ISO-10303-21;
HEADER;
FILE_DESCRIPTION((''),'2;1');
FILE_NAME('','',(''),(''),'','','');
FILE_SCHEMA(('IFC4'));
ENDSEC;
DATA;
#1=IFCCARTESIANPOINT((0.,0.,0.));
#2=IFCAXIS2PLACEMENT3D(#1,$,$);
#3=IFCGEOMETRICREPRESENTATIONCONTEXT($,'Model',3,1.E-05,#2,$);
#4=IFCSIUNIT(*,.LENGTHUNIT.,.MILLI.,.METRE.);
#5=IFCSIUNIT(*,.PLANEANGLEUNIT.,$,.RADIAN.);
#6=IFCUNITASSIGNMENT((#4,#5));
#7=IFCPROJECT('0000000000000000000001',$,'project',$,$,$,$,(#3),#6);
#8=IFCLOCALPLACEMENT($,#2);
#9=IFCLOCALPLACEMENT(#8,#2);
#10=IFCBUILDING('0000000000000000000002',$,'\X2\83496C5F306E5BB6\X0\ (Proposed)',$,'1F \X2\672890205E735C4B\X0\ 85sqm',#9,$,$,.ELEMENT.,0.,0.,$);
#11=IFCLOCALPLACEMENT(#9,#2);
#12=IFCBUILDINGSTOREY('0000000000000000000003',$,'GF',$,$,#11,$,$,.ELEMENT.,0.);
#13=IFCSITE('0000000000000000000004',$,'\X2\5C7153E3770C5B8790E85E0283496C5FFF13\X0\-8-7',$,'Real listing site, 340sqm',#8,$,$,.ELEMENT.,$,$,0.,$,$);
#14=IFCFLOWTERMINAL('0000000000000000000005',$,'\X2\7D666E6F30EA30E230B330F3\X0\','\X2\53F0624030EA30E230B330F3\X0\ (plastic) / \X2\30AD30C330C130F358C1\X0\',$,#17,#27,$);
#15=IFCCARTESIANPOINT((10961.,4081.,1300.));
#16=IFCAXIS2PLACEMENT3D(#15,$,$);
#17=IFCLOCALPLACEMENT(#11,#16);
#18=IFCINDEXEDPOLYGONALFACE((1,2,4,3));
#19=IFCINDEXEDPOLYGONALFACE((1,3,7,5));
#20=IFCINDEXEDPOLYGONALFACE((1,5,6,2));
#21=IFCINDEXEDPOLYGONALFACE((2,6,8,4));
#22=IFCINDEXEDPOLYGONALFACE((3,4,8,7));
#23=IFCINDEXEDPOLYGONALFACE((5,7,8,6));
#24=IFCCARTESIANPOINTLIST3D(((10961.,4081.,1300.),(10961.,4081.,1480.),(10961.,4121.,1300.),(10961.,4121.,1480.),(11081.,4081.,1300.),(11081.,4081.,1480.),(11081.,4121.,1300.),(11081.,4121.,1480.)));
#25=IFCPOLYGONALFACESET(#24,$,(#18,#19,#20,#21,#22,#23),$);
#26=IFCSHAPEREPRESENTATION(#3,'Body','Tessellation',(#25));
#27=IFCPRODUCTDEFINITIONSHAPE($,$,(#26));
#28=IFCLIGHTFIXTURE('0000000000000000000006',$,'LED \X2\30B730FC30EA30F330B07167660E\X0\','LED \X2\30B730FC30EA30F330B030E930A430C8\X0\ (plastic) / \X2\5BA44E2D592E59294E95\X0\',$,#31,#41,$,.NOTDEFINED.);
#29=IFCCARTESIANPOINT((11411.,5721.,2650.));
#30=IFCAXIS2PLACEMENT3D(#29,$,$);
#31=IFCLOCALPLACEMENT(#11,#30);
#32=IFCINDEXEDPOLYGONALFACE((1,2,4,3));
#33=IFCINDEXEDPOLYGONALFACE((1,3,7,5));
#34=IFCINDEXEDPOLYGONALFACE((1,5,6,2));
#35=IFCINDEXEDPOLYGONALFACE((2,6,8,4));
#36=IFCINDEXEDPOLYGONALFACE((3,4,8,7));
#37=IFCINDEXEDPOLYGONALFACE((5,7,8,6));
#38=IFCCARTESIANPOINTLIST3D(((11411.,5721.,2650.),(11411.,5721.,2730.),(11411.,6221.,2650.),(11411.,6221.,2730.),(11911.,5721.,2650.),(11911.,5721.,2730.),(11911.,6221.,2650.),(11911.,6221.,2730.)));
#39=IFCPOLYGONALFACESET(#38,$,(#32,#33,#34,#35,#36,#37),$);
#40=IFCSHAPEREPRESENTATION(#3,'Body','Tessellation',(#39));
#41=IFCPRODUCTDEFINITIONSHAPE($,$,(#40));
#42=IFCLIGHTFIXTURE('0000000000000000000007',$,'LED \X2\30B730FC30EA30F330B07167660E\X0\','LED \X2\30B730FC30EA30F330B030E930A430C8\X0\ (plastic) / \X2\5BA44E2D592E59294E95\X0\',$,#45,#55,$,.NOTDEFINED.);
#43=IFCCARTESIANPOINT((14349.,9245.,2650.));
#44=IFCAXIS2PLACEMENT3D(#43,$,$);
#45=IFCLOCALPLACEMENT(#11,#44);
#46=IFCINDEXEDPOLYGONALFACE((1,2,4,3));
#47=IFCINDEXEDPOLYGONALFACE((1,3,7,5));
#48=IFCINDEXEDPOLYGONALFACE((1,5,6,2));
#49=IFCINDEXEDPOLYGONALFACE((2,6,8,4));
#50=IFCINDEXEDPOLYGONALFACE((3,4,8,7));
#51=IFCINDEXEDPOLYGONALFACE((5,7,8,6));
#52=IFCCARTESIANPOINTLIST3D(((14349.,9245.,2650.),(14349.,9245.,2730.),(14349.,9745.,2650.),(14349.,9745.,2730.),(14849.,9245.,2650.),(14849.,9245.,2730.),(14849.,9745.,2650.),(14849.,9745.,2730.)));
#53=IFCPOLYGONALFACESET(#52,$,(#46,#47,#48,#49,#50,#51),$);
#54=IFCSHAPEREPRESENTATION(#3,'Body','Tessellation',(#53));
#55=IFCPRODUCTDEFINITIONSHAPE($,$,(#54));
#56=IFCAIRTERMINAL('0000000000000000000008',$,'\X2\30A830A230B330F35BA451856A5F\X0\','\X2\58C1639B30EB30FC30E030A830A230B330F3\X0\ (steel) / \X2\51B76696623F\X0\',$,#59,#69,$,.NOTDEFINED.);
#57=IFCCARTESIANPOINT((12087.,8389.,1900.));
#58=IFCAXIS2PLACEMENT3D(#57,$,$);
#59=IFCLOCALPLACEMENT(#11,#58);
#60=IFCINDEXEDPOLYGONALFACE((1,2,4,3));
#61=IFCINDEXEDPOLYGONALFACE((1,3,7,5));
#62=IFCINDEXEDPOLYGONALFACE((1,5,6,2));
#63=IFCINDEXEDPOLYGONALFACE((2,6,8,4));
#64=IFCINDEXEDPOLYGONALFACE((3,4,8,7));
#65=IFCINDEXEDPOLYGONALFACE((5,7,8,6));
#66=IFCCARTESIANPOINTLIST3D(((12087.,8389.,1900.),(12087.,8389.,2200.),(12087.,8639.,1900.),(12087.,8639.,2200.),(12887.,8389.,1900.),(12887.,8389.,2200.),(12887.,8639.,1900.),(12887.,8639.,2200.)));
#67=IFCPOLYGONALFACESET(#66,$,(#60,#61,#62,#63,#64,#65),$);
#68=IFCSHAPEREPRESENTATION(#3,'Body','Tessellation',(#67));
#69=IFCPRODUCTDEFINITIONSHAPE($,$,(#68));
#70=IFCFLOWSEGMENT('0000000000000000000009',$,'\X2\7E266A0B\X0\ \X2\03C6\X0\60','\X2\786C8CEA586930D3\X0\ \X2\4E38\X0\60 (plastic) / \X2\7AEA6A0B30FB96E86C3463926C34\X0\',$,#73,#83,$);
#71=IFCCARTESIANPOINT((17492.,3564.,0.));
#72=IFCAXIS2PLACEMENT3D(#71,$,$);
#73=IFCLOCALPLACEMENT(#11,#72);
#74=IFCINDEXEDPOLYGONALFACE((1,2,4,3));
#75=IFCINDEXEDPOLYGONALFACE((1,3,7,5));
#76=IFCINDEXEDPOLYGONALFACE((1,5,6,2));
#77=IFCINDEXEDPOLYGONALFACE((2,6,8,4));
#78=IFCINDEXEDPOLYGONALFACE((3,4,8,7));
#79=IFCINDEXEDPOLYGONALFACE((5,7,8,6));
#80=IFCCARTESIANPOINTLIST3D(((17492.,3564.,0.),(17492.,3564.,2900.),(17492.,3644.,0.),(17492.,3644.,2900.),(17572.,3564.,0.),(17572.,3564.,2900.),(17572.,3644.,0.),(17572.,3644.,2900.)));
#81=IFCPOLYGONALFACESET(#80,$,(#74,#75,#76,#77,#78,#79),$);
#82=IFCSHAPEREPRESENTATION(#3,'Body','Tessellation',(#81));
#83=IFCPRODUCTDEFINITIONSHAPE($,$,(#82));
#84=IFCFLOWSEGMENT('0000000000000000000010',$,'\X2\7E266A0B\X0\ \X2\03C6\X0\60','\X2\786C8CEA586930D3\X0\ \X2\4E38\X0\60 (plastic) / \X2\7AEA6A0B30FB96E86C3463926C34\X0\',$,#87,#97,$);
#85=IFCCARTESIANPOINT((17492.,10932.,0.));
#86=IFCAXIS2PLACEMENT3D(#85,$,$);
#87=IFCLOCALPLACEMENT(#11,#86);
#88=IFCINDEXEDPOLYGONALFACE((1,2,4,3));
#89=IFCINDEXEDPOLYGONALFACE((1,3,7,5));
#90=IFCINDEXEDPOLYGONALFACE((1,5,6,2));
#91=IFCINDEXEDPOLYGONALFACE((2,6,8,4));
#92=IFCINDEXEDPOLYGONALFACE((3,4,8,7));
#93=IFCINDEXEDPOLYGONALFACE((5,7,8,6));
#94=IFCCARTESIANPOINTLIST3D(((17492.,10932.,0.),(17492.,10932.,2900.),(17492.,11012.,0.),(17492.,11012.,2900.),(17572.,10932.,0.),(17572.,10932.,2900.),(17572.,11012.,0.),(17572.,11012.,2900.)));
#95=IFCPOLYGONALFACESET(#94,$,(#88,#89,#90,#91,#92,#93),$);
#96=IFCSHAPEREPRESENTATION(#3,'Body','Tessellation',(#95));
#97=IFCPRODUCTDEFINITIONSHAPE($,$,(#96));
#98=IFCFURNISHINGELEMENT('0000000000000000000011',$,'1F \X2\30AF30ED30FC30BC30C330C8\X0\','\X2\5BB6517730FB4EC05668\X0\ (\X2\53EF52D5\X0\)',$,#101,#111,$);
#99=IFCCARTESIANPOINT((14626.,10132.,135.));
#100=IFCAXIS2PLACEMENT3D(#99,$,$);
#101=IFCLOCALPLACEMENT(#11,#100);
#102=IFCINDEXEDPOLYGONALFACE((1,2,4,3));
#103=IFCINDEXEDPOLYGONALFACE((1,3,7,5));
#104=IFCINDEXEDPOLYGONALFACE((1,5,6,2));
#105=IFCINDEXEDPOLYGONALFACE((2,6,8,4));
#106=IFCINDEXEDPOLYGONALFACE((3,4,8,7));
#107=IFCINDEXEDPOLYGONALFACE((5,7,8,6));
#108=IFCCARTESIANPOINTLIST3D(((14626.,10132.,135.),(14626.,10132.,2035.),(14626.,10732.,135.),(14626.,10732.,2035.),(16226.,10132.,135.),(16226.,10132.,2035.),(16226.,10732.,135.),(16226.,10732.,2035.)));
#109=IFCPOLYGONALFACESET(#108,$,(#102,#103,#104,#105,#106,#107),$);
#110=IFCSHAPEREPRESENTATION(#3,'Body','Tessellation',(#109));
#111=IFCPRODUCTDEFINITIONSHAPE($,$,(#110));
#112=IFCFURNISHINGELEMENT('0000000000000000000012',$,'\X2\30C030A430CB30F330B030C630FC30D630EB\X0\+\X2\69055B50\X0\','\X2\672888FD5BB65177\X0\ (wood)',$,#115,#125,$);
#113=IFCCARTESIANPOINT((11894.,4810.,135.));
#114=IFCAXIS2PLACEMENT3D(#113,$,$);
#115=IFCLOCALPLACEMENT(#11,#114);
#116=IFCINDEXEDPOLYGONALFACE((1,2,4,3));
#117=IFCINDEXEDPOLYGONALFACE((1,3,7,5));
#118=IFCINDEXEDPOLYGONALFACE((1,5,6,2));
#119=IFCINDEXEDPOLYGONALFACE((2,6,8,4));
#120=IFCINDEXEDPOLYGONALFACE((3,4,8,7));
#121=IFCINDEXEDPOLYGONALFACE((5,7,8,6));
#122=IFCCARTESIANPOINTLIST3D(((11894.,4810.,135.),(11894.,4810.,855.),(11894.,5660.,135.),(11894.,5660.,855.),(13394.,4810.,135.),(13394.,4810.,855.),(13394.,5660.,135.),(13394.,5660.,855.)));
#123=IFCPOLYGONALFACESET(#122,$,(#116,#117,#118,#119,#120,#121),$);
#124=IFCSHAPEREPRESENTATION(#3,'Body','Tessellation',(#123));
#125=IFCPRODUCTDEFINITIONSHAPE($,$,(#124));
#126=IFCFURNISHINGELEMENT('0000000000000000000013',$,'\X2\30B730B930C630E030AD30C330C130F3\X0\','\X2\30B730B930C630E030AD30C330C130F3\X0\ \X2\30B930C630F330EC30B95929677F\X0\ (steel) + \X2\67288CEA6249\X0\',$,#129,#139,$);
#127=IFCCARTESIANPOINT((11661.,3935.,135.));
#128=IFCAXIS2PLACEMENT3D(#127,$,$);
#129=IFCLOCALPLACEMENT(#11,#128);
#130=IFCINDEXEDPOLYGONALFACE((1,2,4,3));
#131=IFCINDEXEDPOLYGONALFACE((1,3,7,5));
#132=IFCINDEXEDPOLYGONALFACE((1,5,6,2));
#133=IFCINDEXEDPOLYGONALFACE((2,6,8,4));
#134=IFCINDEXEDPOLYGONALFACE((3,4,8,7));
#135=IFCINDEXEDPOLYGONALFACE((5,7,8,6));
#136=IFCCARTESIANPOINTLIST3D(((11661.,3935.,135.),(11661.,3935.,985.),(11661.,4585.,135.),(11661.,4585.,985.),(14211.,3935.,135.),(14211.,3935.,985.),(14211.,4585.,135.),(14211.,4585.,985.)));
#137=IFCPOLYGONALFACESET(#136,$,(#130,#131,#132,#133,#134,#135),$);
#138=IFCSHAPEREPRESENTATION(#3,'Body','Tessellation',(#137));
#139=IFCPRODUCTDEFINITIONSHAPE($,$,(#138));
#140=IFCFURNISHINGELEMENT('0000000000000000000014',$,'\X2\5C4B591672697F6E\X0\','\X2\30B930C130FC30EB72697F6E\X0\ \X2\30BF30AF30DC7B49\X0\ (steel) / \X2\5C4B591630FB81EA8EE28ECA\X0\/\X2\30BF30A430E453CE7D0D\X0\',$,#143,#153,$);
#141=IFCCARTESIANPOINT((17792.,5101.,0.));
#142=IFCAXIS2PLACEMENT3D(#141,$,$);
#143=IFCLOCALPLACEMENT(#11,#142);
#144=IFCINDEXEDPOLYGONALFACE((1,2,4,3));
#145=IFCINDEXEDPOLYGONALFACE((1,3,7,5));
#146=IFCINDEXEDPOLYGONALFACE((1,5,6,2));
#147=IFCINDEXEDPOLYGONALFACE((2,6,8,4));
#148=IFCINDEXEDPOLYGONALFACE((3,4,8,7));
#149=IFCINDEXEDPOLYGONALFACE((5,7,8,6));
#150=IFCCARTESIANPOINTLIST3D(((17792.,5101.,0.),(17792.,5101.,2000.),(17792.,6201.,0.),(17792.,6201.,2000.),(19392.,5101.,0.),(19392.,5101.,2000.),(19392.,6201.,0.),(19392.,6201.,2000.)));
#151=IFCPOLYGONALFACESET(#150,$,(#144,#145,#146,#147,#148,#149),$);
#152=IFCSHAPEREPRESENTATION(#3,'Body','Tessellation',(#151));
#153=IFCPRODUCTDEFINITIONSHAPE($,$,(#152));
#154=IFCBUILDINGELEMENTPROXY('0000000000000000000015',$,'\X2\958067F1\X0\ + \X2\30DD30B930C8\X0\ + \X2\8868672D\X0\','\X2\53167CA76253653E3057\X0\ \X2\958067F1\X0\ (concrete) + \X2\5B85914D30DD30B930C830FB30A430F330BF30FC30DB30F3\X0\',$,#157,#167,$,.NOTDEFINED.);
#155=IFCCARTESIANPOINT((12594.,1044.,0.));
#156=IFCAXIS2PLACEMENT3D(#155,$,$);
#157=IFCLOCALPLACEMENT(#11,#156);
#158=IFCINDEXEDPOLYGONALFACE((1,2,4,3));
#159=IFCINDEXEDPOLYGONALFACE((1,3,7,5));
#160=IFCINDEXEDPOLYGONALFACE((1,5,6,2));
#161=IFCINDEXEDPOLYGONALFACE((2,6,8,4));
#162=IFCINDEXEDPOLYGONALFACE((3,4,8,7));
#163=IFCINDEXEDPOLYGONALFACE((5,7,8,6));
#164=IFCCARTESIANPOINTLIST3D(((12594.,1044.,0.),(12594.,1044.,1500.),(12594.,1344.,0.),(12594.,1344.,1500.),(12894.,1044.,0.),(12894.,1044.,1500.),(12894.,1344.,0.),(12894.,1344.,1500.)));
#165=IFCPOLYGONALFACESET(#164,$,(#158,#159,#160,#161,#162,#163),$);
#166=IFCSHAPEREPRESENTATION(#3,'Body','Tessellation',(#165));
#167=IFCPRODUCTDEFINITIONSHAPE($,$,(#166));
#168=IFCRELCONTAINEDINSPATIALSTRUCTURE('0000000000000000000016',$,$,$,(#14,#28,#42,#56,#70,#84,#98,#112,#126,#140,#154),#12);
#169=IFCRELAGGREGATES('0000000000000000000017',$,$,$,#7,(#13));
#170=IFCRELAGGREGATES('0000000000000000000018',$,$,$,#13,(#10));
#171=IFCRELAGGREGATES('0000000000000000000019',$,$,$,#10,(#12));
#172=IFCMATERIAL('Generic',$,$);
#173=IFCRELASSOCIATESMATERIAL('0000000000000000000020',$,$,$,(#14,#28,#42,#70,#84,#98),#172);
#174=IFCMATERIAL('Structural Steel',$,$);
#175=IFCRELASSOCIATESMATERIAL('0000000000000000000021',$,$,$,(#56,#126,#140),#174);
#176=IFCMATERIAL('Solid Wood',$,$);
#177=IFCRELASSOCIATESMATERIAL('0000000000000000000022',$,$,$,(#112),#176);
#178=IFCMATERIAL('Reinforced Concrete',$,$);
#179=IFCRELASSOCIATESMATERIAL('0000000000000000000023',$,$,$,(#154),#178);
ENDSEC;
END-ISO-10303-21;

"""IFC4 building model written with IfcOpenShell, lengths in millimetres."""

from ifc_helpers import new_model, si_unit, frame, frame_2d, origin, place, context, project, spatial, rectangle, extrude, material, element, save


model = new_model("IFC4")

# Units and contexts
model_context = context("Model", 3, precision=1e-05, world=origin())
ifc_project = project(units=[si_unit("LENGTHUNIT", "METRE", prefix="MILLI"), si_unit("PLANEANGLEUNIT", "RADIAN")], contexts=[model_context])

# Site, building, storey
site_placement = place(None, origin())
site = spatial("IfcSite", under=ifc_project, at=site_placement, Name="山口県宇部市草江３-8-7", ObjectType="Real listing site, 340sqm", CompositionType="ELEMENT", RefElevation=0.0)
building_placement = place(site_placement, origin())
building = spatial("IfcBuilding", under=site, at=building_placement, Name="草江の家 (Proposed)", ObjectType="1F 木造平屋 85sqm", CompositionType="ELEMENT", ElevationOfRefHeight=0.0, ElevationOfTerrain=0.0)
storey_placement = place(building_placement, origin())
storey = spatial("IfcBuildingStorey", under=building, at=storey_placement, Name="GF", CompositionType="ELEMENT", Elevation=0.0)

# Shared definitions
ifc_material_1 = material(Name="Solid Wood")

# Shared definitions
ifc_material_2 = material(Name="Reinforced Concrete")

# Shared definitions
ifc_material_3 = material(Name="Generic")

# Shared definitions
ifc_material_4 = material(Name="Structural Steel")

# Flow terminal
flow_terminal_1_placement = place(storey_placement, frame((10961.0, 4081.0, 1300.0)))
element("IfcFlowTerminal", 1, at=flow_terminal_1_placement, inside=storey, material=ifc_material_3, Name="給湯リモコン", Description="台所リモコン (plastic) / キッチン壁", context=model_context, shape_type="SweptSolid", body=[
    extrude(rectangle(XDim=120.0, YDim=40.0, at=frame_2d((60.0, 20.0))), frame((10961.0, 4081.0, 1300.0)), (0.0, 0.0, 1.0), 180.0),
])

# Light fixtures
light_fixture_1_placement = place(storey_placement, frame((11411.0, 5721.0, 2650.0)))
element("IfcLightFixture", 2, at=light_fixture_1_placement, inside=storey, material=ifc_material_3, Name="LED シーリング照明", Description="LED シーリングライト (plastic) / 室中央天井", PredefinedType="NOTDEFINED", context=model_context, shape_type="SweptSolid", body=[
    extrude(rectangle(XDim=500.0, YDim=500.0, at=frame_2d((250.0, 250.0))), frame((11411.0, 5721.0, 2650.0)), (0.0, 0.0, 1.0), 80.0),
])
light_fixture_2_placement = place(storey_placement, frame((14349.0, 9245.0, 2650.0)))
element("IfcLightFixture", 3, at=light_fixture_2_placement, inside=storey, material=ifc_material_3, Name="LED シーリング照明", Description="LED シーリングライト (plastic) / 室中央天井", PredefinedType="NOTDEFINED", context=model_context, shape_type="SweptSolid", body=[
    extrude(rectangle(XDim=500.0, YDim=500.0, at=frame_2d((250.0, 250.0))), frame((14349.0, 9245.0, 2650.0)), (0.0, 0.0, 1.0), 80.0),
])

# Air terminal
air_terminal_placement = place(storey_placement, frame((12087.0, 8389.0, 1900.0)))
element("IfcAirTerminal", 4, at=air_terminal_placement, inside=storey, material=ifc_material_4, Name="エアコン室内機", Description="壁掛ルームエアコン (steel) / 冷暖房", PredefinedType="NOTDEFINED", context=model_context, shape_type="SweptSolid", body=[
    extrude(rectangle(XDim=800.0, YDim=250.0, at=frame_2d((400.0, 125.0))), frame((12087.0, 8389.0, 1900.0)), (0.0, 0.0, 1.0), 300.0),
])

# Flow segments
flow_segment_1_placement = place(storey_placement, frame((17492.0, 3564.0, 0.0)))
element("IfcFlowSegment", 5, at=flow_segment_1_placement, inside=storey, material=ifc_material_3, Name="縦樋 φ60", Description="硬質塩ビ 丸60 (plastic) / 竪樋・雨水排水", context=model_context, shape_type="SweptSolid", body=[
    extrude(rectangle(XDim=80.0, YDim=80.0, at=frame_2d((40.0, 40.0))), frame((17492.0, 3564.0, 0.0)), (0.0, 0.0, 1.0), 2900.0),
])
flow_segment_2_placement = place(storey_placement, frame((17492.0, 10932.0, 0.0)))
element("IfcFlowSegment", 6, at=flow_segment_2_placement, inside=storey, material=ifc_material_3, Name="縦樋 φ60", Description="硬質塩ビ 丸60 (plastic) / 竪樋・雨水排水", context=model_context, shape_type="SweptSolid", body=[
    extrude(rectangle(XDim=80.0, YDim=80.0, at=frame_2d((40.0, 40.0))), frame((17492.0, 10932.0, 0.0)), (0.0, 0.0, 1.0), 2900.0),
])

# Furnishing elements
furnishing_1_placement = place(storey_placement, frame((14626.0, 10132.0, 135.0)))
element("IfcFurnishingElement", 7, at=furnishing_1_placement, inside=storey, material=ifc_material_3, Name="1F クローゼット", Description="家具・什器 (可動)", context=model_context, shape_type="SweptSolid", body=[
    extrude(rectangle(XDim=1600.0, YDim=600.0, at=frame_2d((800.0, 300.0))), frame((14626.0, 10132.0, 135.0)), (0.0, 0.0, 1.0), 1900.0),
])
furnishing_2_placement = place(storey_placement, frame((11894.0, 4810.0, 135.0)))
element("IfcFurnishingElement", 8, at=furnishing_2_placement, inside=storey, material=ifc_material_1, Name="ダイニングテーブル+椅子", Description="木製家具 (wood)", context=model_context, shape_type="SweptSolid", body=[
    extrude(rectangle(XDim=1500.0, YDim=850.0, at=frame_2d((750.0, 425.0))), frame((11894.0, 4810.0, 135.0)), (0.0, 0.0, 1.0), 720.0),
])
furnishing_3_placement = place(storey_placement, frame((11661.0, 3935.0, 135.0)))
element("IfcFurnishingElement", 9, at=furnishing_3_placement, inside=storey, material=ifc_material_4, Name="システムキッチン", Description="システムキッチン ステンレス天板 (steel) + 木質扉", context=model_context, shape_type="SweptSolid", body=[
    extrude(rectangle(XDim=2550.0, YDim=650.0, at=frame_2d((1275.0, 325.0))), frame((11661.0, 3935.0, 135.0)), (0.0, 0.0, 1.0), 850.0),
])
furnishing_4_placement = place(storey_placement, frame((17792.0, 5101.0, 0.0)))
element("IfcFurnishingElement", 10, at=furnishing_4_placement, inside=storey, material=ifc_material_4, Name="屋外物置", Description="スチール物置 タクボ等 (steel) / 屋外・自転車/タイヤ収納", context=model_context, shape_type="SweptSolid", body=[
    extrude(rectangle(XDim=1600.0, YDim=1100.0, at=frame_2d((800.0, 550.0))), frame((17792.0, 5101.0, 0.0)), (0.0, 0.0, 1.0), 2000.0),
])

# Building element proxy
proxy_placement = place(storey_placement, frame((12594.0, 1044.0, 0.0)))
element("IfcBuildingElementProxy", 11, at=proxy_placement, inside=storey, material=ifc_material_2, Name="門柱 + ポスト + 表札", Description="化粧打放し 門柱 (concrete) + 宅配ポスト・インターホン", PredefinedType="NOTDEFINED", context=model_context, shape_type="SweptSolid", body=[
    extrude(rectangle(XDim=300.0, YDim=300.0, at=frame_2d((150.0, 150.0))), frame((12594.0, 1044.0, 0.0)), (0.0, 0.0, 1.0), 1500.0),
])

save(model, "model.ifc")
